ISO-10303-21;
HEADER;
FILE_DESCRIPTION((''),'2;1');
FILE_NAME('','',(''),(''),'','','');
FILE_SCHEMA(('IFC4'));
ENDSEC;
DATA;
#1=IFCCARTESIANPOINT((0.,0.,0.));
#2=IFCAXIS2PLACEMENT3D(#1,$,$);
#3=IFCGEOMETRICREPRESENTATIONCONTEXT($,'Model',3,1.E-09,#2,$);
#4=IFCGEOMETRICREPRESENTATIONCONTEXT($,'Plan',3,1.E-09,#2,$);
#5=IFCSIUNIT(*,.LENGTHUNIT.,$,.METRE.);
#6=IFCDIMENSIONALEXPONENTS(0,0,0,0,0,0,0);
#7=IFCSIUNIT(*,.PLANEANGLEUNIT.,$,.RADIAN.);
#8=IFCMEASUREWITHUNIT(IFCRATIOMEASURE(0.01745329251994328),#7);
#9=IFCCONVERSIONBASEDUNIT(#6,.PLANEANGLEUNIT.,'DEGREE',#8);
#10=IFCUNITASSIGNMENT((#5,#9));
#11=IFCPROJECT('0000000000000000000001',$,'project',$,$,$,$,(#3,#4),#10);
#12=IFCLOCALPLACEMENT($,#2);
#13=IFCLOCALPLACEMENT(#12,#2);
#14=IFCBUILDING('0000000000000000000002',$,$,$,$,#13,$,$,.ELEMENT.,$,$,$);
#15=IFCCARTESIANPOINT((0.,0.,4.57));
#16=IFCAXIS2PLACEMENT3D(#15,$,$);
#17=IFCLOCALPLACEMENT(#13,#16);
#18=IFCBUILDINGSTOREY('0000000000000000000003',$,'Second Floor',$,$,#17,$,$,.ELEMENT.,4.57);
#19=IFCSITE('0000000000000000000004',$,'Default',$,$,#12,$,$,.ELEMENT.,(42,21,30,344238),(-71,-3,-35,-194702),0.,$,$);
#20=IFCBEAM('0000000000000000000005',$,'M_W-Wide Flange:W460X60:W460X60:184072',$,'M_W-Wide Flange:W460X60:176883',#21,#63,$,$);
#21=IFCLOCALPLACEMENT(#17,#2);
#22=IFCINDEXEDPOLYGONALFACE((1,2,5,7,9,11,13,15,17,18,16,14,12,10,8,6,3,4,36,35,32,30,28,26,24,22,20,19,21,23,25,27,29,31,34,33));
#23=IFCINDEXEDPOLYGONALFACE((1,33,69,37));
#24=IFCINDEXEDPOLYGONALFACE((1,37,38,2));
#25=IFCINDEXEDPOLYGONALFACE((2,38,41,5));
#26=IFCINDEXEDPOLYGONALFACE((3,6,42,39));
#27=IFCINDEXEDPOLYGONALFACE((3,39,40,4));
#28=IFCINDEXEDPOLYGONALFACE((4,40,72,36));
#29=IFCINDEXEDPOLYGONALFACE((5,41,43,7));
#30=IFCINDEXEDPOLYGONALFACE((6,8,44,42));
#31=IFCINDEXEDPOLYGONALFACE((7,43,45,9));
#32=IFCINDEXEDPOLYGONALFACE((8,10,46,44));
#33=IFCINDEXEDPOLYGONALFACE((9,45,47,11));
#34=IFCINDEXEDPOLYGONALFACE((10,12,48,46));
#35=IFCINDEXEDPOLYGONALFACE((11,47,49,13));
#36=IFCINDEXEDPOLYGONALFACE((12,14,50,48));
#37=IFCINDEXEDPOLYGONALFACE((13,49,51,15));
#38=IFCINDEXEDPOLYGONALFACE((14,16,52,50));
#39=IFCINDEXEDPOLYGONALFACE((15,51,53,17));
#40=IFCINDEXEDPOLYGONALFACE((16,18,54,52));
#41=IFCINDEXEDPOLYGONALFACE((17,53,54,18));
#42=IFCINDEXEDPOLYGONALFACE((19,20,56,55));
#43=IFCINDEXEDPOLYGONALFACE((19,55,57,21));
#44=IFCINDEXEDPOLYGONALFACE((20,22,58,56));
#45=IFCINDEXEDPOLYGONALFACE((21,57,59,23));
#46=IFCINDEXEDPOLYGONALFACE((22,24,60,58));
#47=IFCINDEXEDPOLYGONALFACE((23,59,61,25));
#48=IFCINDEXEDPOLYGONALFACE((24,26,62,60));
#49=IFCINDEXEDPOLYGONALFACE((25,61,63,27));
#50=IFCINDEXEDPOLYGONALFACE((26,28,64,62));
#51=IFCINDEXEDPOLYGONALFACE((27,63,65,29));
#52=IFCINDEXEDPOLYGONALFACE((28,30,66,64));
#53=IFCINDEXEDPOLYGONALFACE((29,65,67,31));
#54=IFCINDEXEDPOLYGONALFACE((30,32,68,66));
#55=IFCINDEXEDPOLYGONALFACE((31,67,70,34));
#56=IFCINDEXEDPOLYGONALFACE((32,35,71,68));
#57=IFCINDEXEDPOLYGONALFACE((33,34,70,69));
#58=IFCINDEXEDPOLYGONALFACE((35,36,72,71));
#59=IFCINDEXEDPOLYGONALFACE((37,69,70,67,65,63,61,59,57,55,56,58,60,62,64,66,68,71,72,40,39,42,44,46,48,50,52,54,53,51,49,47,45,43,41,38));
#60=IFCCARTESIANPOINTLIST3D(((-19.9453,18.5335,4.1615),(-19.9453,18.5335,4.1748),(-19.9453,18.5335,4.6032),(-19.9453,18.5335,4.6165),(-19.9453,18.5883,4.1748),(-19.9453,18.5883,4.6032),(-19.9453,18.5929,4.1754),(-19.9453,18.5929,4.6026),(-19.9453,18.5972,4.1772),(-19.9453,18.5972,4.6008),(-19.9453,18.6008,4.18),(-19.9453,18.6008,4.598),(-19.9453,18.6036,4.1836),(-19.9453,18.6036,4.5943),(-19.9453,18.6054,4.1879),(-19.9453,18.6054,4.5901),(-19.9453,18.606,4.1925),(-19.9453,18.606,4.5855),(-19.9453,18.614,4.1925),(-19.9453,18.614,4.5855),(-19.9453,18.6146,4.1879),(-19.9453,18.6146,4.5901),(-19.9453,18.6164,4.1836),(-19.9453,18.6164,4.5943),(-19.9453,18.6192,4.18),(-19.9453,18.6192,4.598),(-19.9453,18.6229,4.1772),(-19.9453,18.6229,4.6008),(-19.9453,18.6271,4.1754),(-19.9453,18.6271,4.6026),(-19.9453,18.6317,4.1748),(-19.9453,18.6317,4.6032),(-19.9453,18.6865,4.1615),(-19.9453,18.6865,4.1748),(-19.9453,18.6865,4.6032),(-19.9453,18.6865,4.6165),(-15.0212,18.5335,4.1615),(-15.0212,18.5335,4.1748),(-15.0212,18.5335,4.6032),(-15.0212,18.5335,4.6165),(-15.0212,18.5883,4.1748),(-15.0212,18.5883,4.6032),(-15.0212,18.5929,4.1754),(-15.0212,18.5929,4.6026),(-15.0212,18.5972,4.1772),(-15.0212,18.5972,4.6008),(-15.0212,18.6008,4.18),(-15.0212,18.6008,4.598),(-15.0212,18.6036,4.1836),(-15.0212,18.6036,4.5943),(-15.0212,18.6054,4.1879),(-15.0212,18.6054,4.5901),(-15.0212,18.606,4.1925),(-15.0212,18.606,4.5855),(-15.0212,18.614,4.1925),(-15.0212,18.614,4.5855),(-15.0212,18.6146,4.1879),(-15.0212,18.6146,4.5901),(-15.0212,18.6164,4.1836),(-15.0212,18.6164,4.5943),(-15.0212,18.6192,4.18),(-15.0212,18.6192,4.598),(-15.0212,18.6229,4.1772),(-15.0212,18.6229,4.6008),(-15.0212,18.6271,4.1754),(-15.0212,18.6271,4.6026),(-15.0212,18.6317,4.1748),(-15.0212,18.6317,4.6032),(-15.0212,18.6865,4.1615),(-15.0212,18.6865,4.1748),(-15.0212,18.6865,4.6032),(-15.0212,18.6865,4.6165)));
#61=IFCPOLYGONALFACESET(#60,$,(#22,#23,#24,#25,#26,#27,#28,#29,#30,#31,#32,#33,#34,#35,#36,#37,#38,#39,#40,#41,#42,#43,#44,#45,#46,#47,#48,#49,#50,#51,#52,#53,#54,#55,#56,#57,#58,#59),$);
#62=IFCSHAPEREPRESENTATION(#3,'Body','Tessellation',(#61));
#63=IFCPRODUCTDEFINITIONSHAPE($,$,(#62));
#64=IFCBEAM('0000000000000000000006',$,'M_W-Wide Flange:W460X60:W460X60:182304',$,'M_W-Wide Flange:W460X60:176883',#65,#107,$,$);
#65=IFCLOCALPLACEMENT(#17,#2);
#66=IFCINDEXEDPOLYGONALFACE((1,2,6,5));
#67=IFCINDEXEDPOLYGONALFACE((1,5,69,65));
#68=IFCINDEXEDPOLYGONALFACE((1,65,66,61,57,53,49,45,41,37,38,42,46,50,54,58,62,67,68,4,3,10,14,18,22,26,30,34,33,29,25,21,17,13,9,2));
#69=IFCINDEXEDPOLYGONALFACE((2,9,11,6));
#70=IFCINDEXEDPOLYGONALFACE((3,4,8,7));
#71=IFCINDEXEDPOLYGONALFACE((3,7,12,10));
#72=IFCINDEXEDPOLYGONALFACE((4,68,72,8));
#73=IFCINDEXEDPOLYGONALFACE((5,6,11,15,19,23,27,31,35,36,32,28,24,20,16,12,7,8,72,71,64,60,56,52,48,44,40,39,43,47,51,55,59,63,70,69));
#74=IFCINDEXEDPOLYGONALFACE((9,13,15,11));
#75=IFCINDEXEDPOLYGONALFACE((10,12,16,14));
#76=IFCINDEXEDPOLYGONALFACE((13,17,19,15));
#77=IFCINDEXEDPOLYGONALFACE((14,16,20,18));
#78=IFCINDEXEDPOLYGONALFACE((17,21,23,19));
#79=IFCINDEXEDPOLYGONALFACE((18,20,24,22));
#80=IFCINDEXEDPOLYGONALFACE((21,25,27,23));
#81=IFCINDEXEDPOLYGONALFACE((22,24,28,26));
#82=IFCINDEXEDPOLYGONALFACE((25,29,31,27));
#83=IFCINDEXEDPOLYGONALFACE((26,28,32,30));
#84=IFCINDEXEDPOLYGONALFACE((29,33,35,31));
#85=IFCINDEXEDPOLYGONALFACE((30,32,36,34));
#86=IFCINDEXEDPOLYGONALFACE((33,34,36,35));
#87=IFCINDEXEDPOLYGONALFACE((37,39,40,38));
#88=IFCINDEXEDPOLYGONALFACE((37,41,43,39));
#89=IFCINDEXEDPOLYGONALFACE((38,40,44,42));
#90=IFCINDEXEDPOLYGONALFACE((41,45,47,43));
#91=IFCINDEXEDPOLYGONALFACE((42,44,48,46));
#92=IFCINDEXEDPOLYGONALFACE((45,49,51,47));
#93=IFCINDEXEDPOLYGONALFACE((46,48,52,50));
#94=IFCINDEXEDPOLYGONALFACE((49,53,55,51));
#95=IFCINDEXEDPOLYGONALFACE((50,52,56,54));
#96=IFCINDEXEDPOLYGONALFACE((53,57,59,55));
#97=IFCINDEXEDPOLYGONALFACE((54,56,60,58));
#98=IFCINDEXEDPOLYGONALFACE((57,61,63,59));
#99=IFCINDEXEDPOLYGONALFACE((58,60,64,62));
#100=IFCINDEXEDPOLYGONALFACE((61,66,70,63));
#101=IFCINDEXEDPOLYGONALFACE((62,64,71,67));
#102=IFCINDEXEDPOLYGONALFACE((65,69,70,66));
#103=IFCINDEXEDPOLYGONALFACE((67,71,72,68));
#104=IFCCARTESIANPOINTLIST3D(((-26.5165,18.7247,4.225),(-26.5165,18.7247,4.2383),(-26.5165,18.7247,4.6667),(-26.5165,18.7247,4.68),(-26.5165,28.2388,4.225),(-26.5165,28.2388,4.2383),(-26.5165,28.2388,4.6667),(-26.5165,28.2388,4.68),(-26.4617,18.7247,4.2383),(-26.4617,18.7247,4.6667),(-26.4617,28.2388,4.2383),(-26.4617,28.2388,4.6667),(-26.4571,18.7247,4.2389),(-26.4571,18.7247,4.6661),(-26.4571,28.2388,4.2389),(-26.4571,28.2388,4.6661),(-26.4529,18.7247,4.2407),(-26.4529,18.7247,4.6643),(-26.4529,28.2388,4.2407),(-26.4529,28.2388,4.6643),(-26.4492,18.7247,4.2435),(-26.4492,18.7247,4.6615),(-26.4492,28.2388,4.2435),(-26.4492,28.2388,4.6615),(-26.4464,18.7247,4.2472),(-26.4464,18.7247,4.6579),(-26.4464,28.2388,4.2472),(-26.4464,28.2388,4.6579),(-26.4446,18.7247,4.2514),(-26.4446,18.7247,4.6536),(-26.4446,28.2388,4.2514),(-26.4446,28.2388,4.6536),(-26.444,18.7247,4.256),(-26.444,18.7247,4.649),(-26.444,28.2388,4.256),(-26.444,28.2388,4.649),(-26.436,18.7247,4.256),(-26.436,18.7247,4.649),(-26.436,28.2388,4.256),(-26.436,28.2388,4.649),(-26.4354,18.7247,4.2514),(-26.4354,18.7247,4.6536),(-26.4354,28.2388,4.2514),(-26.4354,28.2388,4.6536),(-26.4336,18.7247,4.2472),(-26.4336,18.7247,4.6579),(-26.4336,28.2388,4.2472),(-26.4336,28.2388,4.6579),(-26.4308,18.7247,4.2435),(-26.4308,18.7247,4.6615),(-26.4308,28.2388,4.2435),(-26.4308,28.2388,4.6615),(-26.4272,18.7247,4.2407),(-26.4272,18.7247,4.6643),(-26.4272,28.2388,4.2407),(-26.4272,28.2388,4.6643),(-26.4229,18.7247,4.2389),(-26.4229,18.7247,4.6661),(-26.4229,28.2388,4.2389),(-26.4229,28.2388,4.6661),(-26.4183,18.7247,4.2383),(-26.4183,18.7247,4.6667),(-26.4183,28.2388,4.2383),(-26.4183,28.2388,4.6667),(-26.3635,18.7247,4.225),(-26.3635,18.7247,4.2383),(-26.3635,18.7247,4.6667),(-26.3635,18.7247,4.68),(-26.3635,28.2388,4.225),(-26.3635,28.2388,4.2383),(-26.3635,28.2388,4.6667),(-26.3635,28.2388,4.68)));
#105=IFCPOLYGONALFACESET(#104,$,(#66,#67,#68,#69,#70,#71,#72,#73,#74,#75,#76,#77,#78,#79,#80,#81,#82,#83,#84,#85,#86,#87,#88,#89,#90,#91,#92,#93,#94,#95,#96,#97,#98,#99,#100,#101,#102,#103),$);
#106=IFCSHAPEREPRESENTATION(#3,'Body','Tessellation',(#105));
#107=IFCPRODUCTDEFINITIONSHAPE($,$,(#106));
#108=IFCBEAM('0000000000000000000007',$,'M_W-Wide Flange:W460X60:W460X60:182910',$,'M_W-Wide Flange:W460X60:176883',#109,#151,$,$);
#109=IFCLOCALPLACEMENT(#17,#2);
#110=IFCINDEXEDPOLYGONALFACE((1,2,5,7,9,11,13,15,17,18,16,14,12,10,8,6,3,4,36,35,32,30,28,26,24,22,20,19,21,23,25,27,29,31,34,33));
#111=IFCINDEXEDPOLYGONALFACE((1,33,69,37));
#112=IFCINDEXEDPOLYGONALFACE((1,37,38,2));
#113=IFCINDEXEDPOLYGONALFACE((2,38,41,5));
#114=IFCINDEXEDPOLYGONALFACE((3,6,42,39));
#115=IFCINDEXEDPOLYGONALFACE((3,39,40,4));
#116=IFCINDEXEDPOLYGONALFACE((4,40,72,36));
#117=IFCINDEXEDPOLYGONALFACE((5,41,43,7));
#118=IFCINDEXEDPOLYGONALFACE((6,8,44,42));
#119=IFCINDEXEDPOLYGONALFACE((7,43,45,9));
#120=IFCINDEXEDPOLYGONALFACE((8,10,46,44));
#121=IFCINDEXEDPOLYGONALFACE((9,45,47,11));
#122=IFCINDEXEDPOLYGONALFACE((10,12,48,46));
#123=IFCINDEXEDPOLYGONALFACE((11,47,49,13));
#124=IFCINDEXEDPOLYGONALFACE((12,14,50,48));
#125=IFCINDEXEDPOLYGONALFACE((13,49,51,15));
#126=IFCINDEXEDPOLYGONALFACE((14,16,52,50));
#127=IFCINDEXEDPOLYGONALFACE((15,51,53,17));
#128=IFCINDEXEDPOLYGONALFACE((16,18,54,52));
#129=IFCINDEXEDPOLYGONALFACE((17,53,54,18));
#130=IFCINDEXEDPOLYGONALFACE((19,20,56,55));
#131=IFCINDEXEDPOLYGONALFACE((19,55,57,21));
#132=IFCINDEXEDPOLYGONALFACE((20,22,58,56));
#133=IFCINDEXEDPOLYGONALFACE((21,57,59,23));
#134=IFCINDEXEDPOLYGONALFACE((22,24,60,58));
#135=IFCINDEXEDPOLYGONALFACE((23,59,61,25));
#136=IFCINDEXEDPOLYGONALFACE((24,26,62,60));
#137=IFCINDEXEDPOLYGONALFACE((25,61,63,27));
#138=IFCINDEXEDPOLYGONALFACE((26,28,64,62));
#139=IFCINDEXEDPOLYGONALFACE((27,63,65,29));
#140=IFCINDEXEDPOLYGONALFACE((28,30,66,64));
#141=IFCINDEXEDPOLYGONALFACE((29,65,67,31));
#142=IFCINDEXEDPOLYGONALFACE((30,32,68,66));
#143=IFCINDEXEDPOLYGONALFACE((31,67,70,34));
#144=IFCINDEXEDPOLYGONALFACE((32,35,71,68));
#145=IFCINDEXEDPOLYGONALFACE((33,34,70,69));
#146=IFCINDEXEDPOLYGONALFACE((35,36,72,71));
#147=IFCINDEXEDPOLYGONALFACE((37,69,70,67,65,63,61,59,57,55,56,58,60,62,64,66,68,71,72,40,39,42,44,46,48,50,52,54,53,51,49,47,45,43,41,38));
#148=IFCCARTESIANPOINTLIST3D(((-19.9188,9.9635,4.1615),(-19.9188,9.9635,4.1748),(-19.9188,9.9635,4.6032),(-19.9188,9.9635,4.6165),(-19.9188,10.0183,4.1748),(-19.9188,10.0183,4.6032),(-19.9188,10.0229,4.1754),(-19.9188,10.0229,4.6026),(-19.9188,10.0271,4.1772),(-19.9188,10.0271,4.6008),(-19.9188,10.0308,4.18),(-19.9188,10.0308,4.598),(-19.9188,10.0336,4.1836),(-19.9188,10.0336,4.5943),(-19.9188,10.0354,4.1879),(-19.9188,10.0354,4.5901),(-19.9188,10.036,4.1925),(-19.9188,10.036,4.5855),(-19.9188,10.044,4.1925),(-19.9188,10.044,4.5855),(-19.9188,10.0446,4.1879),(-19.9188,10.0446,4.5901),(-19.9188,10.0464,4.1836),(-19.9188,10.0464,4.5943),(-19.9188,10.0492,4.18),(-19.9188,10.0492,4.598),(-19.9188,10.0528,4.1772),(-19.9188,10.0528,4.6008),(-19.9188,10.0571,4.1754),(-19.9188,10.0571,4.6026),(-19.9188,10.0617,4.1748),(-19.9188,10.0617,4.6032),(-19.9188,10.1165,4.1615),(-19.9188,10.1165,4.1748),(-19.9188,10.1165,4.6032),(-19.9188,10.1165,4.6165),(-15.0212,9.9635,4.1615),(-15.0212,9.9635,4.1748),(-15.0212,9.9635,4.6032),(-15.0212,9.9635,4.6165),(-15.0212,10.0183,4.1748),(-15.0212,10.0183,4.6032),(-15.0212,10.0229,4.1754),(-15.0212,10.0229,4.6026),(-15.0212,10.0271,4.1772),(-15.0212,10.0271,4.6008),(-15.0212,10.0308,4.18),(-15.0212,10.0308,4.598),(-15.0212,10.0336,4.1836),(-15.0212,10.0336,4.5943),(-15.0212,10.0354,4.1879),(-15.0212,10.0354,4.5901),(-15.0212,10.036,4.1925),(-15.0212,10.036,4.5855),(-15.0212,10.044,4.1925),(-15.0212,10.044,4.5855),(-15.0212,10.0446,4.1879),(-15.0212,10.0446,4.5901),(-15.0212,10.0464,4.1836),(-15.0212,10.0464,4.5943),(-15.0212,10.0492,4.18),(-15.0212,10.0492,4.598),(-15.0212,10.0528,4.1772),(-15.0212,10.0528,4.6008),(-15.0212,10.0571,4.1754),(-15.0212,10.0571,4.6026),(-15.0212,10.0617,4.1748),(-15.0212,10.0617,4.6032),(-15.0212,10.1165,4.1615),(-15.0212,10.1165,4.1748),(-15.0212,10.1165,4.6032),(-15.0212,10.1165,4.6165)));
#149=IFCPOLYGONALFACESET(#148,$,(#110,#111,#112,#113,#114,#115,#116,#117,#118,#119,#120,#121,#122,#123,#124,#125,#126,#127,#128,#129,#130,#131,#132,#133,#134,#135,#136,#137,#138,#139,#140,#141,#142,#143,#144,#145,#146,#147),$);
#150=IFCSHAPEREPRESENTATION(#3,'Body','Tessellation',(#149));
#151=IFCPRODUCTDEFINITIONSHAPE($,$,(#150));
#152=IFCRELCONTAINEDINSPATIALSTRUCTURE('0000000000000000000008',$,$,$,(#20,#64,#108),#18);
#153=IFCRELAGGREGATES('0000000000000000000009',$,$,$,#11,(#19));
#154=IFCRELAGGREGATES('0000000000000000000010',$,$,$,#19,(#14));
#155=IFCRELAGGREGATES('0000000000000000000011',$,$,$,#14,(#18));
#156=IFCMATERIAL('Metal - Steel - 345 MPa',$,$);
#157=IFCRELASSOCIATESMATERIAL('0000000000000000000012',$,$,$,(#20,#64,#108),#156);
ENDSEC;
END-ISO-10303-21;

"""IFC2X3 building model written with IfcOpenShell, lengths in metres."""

from ifc_helpers import new_model, entity, si_unit, converted_unit, frame, frame_2d, origin, place, context, project, spatial, polyline, circle_curve, parameter, trimmed, segment, composite_curve, outline, extrude, material, element, save


model = new_model("IFC2X3")

# Units and contexts
model_context = context("Model", 3, precision=1e-09, world=origin())
plan_context = context("Plan", 3, precision=1e-09, world=origin())
ifc_project = project(units=[si_unit("LENGTHUNIT", "METRE"), converted_unit("PLANEANGLEUNIT", "DEGREE", entity("IfcRatioMeasure", 0.01745329251994328), si_unit("PLANEANGLEUNIT", "RADIAN"), dimensions=[0, 0, 0, 0, 0, 0, 0])], contexts=[model_context, plan_context])

# Site, building, storey
site_placement = place(None, origin())
site = spatial("IfcSite", under=ifc_project, at=site_placement, Name="Default", CompositionType="ELEMENT", RefLatitude=(42, 21, 30, 344238), RefLongitude=(-71, -3, -35, -194702), RefElevation=0.0)
building_placement = place(site_placement, origin())
building = spatial("IfcBuilding", under=site, at=building_placement, CompositionType="ELEMENT")
storey_placement = place(building_placement, frame((0.0, 0.0, 4.57)))
storey = spatial("IfcBuildingStorey", under=building, at=storey_placement, Name="Second Floor", CompositionType="ELEMENT", Elevation=4.57)

# Shared definitions
ifc_material = material(Name="Metal - Steel - 345 MPa")

# Beams
beam_1_placement = place(storey_placement, frame((-14.8836, 18.61, 4.6165), z_axis=(0.0, 0.0, 1.0), x_axis=(0.0, 1.0, 0.0)))
element("IfcBeam", 1, at=beam_1_placement, inside=storey, material=ifc_material, Name="M_W-Wide Flange:W460X60:W460X60:184072", ObjectType="M_W-Wide Flange:W460X60:176883", context=model_context, shape_type="SweptSolid", body=[
    extrude(outline(composite_curve([segment(polyline([(0.2142, -0.0765), (0.2275, -0.0765)]), True, "CONTINUOUS"), segment(polyline([(0.2275, -0.0765), (0.2275, 0.0765)]), True, "CONTINUOUS"), segment(polyline([(0.2275, 0.0765), (0.2142, 0.0765)]), True, "CONTINUOUS"), segment(polyline([(0.2142, 0.0765), (0.2142, 0.0217)]), True, "CONTINUOUS"), segment(trimmed(circle_curve(frame_2d((0.1965, 0.0217), x_axis=(0.0, 1.0)), 0.0177), [parameter(180.0)], [parameter(270.0)], True, "PARAMETER"), False, "CONTINUOUS"), segment(polyline([(0.1965, 0.004), (-0.1965, 0.004)]), True, "CONTINUOUS"), segment(trimmed(circle_curve(frame_2d((-0.1965, 0.0217), x_axis=(0.0, 1.0)), 0.0177), [parameter(90.0)], [parameter(180.0)], True, "PARAMETER"), False, "CONTINUOUS"), segment(polyline([(-0.2142, 0.0217), (-0.2142, 0.0765)]), True, "CONTINUOUS"), segment(polyline([(-0.2142, 0.0765), (-0.2275, 0.0765)]), True, "CONTINUOUS"), segment(polyline([(-0.2275, 0.0765), (-0.2275, -0.0765)]), True, "CONTINUOUS"), segment(polyline([(-0.2275, -0.0765), (-0.2142, -0.0765)]), True, "CONTINUOUS"), segment(polyline([(-0.2142, -0.0765), (-0.2142, -0.0217)]), True, "CONTINUOUS"), segment(trimmed(circle_curve(frame_2d((-0.1965, -0.0217), x_axis=(0.0, 1.0)), 0.0177), [parameter(360.0)], [parameter(90.0)], True, "PARAMETER"), False, "CONTINUOUS"), segment(polyline([(-0.1965, -0.004), (0.1965, -0.004)]), True, "CONTINUOUS"), segment(trimmed(circle_curve(frame_2d((0.1965, -0.0217), x_axis=(0.0, 1.0)), 0.0177), [parameter(270.0)], [parameter(0.0)], True, "PARAMETER"), False, "CONTINUOUS"), segment(polyline([(0.2142, -0.0217), (0.2142, -0.0765)]), True, "CONTINUOUS")], self_intersect=False)), frame((0.0, 5.0617, -0.2275), z_axis=(0.0, -1.0, 0.0), x_axis=(0.0, 0.0, -1.0)), (0.0, 0.0, 1.0), 4.9241),
])
beam_2_placement = place(storey_placement, frame((-26.44, 28.3781, 4.68), z_axis=(0.0, 0.0, 1.0), x_axis=(-1.0, 0.0, 0.0)))
element("IfcBeam", 2, at=beam_2_placement, inside=storey, material=ifc_material, Name="M_W-Wide Flange:W460X60:W460X60:182304", ObjectType="M_W-Wide Flange:W460X60:176883", context=model_context, shape_type="SweptSolid", body=[
    extrude(outline(composite_curve([segment(polyline([(0.2142, -0.0765), (0.2275, -0.0765)]), True, "CONTINUOUS"), segment(polyline([(0.2275, -0.0765), (0.2275, 0.0765)]), True, "CONTINUOUS"), segment(polyline([(0.2275, 0.0765), (0.2142, 0.0765)]), True, "CONTINUOUS"), segment(polyline([(0.2142, 0.0765), (0.2142, 0.0217)]), True, "CONTINUOUS"), segment(trimmed(circle_curve(frame_2d((0.1965, 0.0217), x_axis=(1.0, 0.0)), 0.0177), [parameter(270.0)], [parameter(360.0)], True, "PARAMETER"), False, "CONTINUOUS"), segment(polyline([(0.1965, 0.004), (-0.1965, 0.004)]), True, "CONTINUOUS"), segment(trimmed(circle_curve(frame_2d((-0.1965, 0.0217), x_axis=(0.0, -1.0)), 0.0177), [parameter(270.0)], [parameter(360.0)], True, "PARAMETER"), False, "CONTINUOUS"), segment(polyline([(-0.2142, 0.0217), (-0.2142, 0.0765)]), True, "CONTINUOUS"), segment(polyline([(-0.2142, 0.0765), (-0.2275, 0.0765)]), True, "CONTINUOUS"), segment(polyline([(-0.2275, 0.0765), (-0.2275, -0.0765)]), True, "CONTINUOUS"), segment(polyline([(-0.2275, -0.0765), (-0.2142, -0.0765)]), True, "CONTINUOUS"), segment(polyline([(-0.2142, -0.0765), (-0.2142, -0.0217)]), True, "CONTINUOUS"), segment(trimmed(circle_curve(frame_2d((-0.1965, -0.0217), x_axis=(-1.0, 0.0)), 0.0177), [parameter(270.0)], [parameter(360.0)], True, "PARAMETER"), False, "CONTINUOUS"), segment(polyline([(-0.1965, -0.004), (0.1965, -0.004)]), True, "CONTINUOUS"), segment(trimmed(circle_curve(frame_2d((0.1965, -0.0217), x_axis=(0.0, 1.0)), 0.0177), [parameter(270.0)], [parameter(0.0)], True, "PARAMETER"), False, "CONTINUOUS"), segment(polyline([(0.2142, -0.0217), (0.2142, -0.0765)]), True, "CONTINUOUS")], self_intersect=False)), frame((0.0, 9.6534, -0.2275), z_axis=(0.0, -1.0, 0.0), x_axis=(0.0, 0.0, -1.0)), (0.0, 0.0, 1.0), 9.5141),
])
beam_3_placement = place(storey_placement, frame((-14.8836, 10.04, 4.6165), z_axis=(0.0, 0.0, 1.0), x_axis=(0.0, 1.0, 0.0)))
element("IfcBeam", 3, at=beam_3_placement, inside=storey, material=ifc_material, Name="M_W-Wide Flange:W460X60:W460X60:182910", ObjectType="M_W-Wide Flange:W460X60:176883", context=model_context, shape_type="SweptSolid", body=[
    extrude(outline(composite_curve([segment(polyline([(0.2142, -0.0765), (0.2275, -0.0765)]), True, "CONTINUOUS"), segment(polyline([(0.2275, -0.0765), (0.2275, 0.0765)]), True, "CONTINUOUS"), segment(polyline([(0.2275, 0.0765), (0.2142, 0.0765)]), True, "CONTINUOUS"), segment(polyline([(0.2142, 0.0765), (0.2142, 0.0217)]), True, "CONTINUOUS"), segment(trimmed(circle_curve(frame_2d((0.1965, 0.0217), x_axis=(1.0, 0.0)), 0.0177), [parameter(270.0)], [parameter(360.0)], True, "PARAMETER"), False, "CONTINUOUS"), segment(polyline([(0.1965, 0.004), (-0.1965, 0.004)]), True, "CONTINUOUS"), segment(trimmed(circle_curve(frame_2d((-0.1965, 0.0217), x_axis=(0.0, -1.0)), 0.0177), [parameter(270.0)], [parameter(360.0)], True, "PARAMETER"), False, "CONTINUOUS"), segment(polyline([(-0.2142, 0.0217), (-0.2142, 0.0765)]), True, "CONTINUOUS"), segment(polyline([(-0.2142, 0.0765), (-0.2275, 0.0765)]), True, "CONTINUOUS"), segment(polyline([(-0.2275, 0.0765), (-0.2275, -0.0765)]), True, "CONTINUOUS"), segment(polyline([(-0.2275, -0.0765), (-0.2142, -0.0765)]), True, "CONTINUOUS"), segment(polyline([(-0.2142, -0.0765), (-0.2142, -0.0217)]), True, "CONTINUOUS"), segment(trimmed(circle_curve(frame_2d((-0.1965, -0.0217), x_axis=(-1.0, 0.0)), 0.0177), [parameter(270.0)], [parameter(360.0)], True, "PARAMETER"), False, "CONTINUOUS"), segment(polyline([(-0.1965, -0.004), (0.1965, -0.004)]), True, "CONTINUOUS"), segment(trimmed(circle_curve(frame_2d((0.1965, -0.0217), x_axis=(0.0, 1.0)), 0.0177), [parameter(270.0)], [parameter(0.0)], True, "PARAMETER"), False, "CONTINUOUS"), segment(polyline([(0.2142, -0.0217), (0.2142, -0.0765)]), True, "CONTINUOUS")], self_intersect=False)), frame((0.0, 5.0352, -0.2275), z_axis=(0.0, -1.0, 0.0), x_axis=(0.0, 0.0, -1.0)), (0.0, 0.0, 1.0), 4.8976),
])

save(model, "model.ifc")
